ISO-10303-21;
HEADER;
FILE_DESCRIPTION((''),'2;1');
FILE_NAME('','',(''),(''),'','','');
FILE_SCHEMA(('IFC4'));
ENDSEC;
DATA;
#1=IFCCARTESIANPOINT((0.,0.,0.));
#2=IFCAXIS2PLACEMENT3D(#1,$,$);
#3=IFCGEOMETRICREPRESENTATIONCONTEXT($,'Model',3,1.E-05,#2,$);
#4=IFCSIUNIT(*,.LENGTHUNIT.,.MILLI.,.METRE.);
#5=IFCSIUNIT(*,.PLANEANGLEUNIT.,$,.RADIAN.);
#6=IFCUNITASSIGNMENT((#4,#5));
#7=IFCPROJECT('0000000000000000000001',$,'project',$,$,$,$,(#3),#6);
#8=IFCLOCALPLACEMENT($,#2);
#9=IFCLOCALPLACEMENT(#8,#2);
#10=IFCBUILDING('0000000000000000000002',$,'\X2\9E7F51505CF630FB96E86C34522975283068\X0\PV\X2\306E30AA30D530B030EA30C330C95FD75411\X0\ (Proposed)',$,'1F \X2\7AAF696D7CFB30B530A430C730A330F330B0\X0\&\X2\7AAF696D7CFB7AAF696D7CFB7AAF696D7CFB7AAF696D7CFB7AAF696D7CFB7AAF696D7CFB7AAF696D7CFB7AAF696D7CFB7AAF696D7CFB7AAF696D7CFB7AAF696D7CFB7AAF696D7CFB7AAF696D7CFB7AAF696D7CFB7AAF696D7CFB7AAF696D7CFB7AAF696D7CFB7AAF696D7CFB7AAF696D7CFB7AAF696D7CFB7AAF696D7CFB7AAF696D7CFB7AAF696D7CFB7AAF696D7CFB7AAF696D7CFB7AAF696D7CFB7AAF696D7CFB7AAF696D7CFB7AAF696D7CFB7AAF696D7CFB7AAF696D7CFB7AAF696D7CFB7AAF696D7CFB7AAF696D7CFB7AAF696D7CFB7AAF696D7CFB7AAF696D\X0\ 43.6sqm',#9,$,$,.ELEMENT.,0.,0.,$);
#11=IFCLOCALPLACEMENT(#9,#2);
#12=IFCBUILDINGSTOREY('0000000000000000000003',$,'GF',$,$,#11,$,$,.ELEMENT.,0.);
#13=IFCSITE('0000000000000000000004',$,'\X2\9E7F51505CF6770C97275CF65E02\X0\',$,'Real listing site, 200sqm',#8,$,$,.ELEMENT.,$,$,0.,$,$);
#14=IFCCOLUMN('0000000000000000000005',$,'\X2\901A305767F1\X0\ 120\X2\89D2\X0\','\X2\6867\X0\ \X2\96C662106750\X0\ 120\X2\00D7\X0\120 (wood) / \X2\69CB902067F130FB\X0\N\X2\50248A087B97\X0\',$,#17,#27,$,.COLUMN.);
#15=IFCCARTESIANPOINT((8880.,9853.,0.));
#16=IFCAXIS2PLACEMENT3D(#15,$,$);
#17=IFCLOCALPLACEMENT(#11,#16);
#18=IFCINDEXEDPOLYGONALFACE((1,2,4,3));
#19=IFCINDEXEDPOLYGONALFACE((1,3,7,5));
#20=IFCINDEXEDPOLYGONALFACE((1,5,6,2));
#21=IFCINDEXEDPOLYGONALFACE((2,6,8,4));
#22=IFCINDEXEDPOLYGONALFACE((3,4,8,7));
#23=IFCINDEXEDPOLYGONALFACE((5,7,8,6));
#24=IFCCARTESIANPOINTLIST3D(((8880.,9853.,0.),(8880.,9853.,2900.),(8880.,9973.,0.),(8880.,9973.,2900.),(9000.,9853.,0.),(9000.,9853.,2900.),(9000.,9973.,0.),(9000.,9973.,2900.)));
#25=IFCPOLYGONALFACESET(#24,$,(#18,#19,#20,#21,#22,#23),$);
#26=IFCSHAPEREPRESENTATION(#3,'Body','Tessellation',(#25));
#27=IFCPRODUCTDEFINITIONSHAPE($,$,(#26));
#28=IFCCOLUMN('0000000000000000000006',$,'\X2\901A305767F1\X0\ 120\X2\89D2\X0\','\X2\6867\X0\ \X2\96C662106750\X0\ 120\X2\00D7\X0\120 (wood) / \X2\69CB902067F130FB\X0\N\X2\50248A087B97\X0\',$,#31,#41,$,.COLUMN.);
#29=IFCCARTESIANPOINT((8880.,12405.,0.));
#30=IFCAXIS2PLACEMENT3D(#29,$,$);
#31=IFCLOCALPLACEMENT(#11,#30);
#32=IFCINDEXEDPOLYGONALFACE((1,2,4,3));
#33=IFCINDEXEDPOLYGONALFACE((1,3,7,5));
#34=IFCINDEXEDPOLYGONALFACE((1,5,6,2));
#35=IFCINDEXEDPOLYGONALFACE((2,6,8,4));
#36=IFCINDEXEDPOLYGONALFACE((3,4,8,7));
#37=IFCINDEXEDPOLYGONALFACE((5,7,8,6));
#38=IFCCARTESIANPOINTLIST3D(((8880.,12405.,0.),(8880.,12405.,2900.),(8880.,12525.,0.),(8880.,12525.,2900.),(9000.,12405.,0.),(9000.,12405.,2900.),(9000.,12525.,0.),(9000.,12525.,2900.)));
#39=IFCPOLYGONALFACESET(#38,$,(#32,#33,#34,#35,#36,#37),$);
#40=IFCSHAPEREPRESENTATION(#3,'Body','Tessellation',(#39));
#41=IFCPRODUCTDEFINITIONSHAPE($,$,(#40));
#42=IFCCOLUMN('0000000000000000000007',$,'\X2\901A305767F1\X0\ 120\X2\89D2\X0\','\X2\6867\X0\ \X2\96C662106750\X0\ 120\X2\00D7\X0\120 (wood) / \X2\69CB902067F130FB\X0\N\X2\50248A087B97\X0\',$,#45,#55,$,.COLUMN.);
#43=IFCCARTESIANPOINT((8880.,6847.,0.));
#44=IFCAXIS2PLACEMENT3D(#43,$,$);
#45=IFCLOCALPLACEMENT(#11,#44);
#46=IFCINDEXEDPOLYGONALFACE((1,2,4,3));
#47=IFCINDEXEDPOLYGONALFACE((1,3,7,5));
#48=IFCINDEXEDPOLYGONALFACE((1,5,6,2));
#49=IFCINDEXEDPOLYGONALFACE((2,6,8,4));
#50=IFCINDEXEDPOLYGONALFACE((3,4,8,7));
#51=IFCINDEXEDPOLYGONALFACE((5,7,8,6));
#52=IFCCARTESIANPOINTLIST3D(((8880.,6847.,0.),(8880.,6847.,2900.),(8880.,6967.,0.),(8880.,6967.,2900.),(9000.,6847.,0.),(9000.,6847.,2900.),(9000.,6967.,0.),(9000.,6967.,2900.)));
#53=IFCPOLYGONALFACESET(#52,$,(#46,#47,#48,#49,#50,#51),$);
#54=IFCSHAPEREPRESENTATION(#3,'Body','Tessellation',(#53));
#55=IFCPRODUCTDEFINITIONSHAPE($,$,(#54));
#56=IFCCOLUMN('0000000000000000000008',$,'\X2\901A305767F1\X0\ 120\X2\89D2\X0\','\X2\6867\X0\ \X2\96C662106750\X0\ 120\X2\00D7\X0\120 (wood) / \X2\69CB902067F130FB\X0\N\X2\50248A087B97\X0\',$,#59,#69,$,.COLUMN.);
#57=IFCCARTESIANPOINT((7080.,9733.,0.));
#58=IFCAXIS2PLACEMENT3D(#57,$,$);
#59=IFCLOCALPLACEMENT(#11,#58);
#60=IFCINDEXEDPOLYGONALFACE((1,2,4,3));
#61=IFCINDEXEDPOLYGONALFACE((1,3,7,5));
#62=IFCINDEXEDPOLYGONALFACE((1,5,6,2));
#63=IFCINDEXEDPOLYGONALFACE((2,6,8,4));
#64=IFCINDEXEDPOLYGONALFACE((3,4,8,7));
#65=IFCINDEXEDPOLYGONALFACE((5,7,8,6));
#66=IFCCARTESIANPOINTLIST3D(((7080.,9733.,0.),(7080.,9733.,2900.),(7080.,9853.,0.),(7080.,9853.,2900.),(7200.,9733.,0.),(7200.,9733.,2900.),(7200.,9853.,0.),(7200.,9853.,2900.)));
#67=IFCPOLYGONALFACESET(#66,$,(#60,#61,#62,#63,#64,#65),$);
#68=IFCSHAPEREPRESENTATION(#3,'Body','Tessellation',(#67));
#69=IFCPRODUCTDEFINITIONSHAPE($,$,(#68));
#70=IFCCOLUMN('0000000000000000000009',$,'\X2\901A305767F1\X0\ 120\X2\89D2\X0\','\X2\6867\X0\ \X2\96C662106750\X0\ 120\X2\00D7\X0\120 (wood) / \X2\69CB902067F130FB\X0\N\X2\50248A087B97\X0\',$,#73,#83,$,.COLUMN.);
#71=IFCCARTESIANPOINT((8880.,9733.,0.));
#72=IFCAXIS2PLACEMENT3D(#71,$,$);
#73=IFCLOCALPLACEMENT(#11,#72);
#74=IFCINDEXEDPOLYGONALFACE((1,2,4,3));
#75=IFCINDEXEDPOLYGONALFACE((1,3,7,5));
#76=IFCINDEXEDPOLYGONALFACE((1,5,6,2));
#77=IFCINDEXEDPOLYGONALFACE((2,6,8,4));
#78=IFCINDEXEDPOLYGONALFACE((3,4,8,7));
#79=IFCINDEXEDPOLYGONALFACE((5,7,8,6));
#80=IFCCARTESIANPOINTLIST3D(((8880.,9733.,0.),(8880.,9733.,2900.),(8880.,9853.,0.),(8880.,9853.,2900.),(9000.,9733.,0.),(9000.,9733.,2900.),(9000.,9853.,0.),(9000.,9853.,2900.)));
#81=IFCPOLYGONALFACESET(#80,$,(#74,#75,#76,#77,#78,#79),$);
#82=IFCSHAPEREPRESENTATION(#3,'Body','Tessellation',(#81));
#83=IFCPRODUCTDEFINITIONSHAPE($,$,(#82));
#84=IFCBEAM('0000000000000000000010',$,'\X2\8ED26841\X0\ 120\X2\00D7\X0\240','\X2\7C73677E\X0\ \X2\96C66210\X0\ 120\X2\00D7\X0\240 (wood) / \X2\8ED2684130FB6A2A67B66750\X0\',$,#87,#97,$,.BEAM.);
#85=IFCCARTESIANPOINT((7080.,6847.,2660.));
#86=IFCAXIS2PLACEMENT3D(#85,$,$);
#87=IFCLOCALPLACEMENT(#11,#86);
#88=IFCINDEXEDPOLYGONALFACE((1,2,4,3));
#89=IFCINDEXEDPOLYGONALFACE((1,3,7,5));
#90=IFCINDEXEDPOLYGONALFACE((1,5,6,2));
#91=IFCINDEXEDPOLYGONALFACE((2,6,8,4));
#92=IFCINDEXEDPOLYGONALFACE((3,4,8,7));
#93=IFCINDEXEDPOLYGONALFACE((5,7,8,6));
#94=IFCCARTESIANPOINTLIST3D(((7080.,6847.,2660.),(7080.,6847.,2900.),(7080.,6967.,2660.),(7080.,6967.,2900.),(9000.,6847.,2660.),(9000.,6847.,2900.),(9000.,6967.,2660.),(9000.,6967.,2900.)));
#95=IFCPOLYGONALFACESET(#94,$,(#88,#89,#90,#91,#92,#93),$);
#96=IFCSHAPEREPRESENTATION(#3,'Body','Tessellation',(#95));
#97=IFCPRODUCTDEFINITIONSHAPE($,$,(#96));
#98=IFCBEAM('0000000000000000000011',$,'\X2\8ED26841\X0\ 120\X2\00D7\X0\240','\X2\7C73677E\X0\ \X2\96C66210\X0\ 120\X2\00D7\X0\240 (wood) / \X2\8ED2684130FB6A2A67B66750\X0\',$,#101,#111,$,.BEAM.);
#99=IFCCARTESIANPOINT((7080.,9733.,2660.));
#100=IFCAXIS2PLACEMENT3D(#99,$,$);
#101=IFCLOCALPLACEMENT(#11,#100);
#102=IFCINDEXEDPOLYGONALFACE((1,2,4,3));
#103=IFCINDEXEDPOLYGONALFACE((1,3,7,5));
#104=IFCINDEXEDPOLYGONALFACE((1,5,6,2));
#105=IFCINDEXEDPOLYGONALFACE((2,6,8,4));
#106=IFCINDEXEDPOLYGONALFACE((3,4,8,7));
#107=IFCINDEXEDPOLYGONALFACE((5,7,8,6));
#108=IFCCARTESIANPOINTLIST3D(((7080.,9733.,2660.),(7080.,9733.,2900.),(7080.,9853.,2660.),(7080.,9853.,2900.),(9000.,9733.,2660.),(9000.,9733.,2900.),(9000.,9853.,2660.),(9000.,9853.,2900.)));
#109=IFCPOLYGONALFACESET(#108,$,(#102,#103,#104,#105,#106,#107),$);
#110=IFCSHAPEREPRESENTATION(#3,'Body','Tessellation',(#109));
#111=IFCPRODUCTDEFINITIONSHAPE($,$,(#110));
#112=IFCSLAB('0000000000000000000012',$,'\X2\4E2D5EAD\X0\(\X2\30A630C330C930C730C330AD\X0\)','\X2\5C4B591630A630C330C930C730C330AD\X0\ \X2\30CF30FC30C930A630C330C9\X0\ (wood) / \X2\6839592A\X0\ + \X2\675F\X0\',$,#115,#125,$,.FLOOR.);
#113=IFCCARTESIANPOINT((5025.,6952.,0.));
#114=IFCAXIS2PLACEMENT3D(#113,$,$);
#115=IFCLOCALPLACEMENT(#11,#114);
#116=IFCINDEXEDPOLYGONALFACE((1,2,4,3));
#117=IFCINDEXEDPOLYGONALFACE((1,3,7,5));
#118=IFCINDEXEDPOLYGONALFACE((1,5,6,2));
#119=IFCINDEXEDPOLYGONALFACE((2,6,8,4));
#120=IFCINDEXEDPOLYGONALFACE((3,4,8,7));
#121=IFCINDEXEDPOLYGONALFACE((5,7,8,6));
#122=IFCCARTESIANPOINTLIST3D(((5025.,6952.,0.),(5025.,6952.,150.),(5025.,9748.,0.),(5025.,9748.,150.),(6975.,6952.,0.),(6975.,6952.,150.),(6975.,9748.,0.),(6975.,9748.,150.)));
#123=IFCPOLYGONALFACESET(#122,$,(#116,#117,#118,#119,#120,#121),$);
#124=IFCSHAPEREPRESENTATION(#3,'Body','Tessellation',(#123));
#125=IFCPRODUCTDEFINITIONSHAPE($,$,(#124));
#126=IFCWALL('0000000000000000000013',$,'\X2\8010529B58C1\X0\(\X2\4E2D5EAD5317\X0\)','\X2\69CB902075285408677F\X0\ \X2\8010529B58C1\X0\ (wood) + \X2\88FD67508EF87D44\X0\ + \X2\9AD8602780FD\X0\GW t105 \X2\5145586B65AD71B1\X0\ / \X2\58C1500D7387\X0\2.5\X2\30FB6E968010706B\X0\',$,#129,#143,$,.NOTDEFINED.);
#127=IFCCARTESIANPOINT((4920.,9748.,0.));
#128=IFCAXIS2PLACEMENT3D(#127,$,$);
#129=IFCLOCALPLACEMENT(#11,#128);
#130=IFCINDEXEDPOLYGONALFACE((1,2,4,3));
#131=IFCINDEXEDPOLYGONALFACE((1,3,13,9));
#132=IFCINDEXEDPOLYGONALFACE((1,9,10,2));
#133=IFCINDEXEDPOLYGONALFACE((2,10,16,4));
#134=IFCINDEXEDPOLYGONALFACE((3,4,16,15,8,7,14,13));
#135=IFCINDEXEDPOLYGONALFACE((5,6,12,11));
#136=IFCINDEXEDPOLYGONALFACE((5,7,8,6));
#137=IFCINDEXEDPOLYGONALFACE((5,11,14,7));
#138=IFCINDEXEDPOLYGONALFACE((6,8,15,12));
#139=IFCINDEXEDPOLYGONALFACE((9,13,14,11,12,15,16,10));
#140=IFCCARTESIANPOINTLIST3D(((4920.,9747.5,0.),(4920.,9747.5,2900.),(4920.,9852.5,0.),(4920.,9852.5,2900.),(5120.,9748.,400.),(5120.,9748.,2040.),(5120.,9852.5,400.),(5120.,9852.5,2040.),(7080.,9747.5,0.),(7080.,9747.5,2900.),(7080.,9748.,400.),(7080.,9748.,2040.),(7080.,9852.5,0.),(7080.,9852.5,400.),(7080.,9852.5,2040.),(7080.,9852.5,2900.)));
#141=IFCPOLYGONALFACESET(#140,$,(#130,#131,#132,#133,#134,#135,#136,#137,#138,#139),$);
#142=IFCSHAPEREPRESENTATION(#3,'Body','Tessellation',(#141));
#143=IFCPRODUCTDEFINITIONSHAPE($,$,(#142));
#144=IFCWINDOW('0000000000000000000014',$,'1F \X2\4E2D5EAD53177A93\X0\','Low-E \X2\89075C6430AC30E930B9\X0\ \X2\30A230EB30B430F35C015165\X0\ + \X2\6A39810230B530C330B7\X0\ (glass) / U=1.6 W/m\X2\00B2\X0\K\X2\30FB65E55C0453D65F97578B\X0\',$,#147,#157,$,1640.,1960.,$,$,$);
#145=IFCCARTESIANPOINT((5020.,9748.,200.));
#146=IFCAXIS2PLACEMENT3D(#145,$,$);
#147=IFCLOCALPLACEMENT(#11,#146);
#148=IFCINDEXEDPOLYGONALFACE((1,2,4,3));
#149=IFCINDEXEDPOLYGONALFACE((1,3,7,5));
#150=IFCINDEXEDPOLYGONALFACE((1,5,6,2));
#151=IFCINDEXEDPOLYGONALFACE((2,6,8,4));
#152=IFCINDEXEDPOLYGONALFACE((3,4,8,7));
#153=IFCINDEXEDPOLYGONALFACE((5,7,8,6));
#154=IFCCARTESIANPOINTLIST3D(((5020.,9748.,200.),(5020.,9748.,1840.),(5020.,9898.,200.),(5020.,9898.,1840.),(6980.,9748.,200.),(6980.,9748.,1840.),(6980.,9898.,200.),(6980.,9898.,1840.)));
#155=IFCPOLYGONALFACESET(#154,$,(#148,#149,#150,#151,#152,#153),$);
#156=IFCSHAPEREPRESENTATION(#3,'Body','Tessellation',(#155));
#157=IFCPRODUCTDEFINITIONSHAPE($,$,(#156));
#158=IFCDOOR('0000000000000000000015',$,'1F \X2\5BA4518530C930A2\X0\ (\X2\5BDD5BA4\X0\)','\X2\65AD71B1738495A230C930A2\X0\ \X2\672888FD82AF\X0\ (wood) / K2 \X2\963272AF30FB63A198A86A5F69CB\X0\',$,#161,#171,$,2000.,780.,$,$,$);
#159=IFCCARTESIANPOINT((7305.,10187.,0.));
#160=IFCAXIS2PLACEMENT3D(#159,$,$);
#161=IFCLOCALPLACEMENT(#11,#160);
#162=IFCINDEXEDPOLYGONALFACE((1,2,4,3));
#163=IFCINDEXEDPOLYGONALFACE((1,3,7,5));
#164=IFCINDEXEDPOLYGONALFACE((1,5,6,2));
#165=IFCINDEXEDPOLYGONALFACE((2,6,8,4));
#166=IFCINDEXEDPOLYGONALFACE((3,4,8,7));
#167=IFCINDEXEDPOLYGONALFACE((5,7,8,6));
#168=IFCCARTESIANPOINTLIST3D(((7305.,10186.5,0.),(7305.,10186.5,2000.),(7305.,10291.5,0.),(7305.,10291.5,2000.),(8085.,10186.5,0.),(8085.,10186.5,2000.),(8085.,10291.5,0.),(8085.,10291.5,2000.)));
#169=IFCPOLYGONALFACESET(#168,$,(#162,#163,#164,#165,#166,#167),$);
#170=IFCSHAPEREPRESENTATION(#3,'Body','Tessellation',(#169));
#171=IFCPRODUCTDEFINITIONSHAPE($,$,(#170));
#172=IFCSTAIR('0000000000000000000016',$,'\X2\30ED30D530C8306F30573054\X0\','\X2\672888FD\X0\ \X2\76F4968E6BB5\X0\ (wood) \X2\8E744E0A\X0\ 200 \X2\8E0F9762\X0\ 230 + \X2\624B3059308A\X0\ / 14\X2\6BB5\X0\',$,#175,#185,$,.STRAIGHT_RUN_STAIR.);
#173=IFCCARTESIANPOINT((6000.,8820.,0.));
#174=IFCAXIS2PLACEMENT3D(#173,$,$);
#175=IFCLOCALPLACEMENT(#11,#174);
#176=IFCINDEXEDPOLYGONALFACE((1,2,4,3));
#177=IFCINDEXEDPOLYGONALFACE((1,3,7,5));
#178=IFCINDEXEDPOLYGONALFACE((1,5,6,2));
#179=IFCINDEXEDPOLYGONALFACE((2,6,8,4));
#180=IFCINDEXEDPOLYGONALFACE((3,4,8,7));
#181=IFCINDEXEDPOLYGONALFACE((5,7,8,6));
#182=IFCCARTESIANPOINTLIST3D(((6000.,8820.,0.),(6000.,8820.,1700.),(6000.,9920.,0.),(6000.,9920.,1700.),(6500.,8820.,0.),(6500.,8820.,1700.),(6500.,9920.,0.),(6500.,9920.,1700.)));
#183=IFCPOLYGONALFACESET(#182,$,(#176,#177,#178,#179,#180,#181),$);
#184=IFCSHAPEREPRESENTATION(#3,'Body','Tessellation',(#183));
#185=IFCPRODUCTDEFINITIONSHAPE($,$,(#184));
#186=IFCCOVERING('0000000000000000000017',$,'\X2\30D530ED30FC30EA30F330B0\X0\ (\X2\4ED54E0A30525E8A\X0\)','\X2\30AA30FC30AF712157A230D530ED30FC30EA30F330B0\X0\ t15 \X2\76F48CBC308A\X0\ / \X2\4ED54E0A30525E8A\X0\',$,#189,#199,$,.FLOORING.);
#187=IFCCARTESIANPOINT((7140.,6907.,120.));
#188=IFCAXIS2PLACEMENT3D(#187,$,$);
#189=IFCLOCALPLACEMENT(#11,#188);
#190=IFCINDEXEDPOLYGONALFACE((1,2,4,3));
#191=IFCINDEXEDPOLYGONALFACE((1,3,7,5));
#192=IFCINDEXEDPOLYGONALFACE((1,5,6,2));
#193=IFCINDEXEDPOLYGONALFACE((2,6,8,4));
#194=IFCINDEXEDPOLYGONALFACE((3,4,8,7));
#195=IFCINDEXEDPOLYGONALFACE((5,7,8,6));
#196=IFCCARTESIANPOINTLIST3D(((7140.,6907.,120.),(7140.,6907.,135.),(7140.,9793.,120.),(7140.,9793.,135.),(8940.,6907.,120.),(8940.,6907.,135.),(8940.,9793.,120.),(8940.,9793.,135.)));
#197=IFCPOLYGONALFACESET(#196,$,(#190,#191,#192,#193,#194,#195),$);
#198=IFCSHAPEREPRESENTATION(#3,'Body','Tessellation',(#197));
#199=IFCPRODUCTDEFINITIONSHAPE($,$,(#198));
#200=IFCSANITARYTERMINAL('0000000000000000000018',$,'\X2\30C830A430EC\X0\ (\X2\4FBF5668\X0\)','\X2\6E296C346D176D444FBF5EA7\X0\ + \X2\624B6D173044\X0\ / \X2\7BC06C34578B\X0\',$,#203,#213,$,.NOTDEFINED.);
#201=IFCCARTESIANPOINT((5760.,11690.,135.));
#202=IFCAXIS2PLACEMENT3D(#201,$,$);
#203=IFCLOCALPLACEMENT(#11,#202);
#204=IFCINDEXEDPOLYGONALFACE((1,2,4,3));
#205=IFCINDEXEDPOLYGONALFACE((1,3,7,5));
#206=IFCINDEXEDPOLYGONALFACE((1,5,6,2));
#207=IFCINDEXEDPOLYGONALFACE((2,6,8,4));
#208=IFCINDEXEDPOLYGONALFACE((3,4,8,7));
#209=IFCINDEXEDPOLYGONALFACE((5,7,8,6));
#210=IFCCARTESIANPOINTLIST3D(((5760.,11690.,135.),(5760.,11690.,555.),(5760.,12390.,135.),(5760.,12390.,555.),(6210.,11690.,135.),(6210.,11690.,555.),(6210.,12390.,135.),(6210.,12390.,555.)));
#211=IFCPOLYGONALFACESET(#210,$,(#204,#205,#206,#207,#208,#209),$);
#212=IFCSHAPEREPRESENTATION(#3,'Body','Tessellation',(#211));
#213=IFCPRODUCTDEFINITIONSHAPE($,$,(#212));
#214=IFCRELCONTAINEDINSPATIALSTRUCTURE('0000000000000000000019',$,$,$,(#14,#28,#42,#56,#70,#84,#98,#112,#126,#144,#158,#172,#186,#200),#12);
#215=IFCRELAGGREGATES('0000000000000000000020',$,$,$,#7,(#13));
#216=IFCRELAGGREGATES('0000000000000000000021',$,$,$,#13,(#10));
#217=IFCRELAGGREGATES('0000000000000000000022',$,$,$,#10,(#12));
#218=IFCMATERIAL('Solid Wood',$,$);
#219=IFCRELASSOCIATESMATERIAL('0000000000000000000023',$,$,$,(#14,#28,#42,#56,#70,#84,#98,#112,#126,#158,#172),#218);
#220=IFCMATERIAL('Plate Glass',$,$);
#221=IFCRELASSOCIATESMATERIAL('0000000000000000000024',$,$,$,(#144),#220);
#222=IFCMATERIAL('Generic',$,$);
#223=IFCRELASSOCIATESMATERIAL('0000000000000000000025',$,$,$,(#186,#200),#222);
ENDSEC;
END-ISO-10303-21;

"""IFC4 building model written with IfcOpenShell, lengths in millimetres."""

from ifc_helpers import new_model, si_unit, frame, frame_2d, origin, place, context, project, spatial, rectangle, extrude, material, element, fill, save


model = new_model("IFC4")

# Units and contexts
model_context = context("Model", 3, precision=1e-05, world=origin())
ifc_project = project(units=[si_unit("LENGTHUNIT", "METRE", prefix="MILLI"), si_unit("PLANEANGLEUNIT", "RADIAN")], contexts=[model_context])

# Site, building, storey
site_placement = place(None, origin())
site = spatial("IfcSite", under=ifc_project, at=site_placement, Name="鹿児島県霧島市", ObjectType="Real listing site, 200sqm", CompositionType="ELEMENT", RefElevation=0.0)
building_placement = place(site_placement, origin())
building = spatial("IfcBuilding", under=site, at=building_placement, Name="鹿児島・雨水利用とPVのオフグリッド志向 (Proposed)", ObjectType="1F 窯業系サイディング&窯業系窯業系窯業系窯業系窯業系窯業系窯業系窯業系窯業系窯業系窯業系窯業系窯業系窯業系窯業系窯業系窯業系窯業系窯業系窯業系窯業系窯業系窯業系窯業系窯業系窯業系窯業系窯業系窯業系窯業系窯業系窯業系窯業系窯業系窯業系窯業系窯業 43.6sqm", CompositionType="ELEMENT", ElevationOfRefHeight=0.0, ElevationOfTerrain=0.0)
storey_placement = place(building_placement, origin())
storey = spatial("IfcBuildingStorey", under=building, at=storey_placement, Name="GF", CompositionType="ELEMENT", Elevation=0.0)

# Columns
ifc_material_1 = material(Name="Solid Wood")
column_1_placement = place(storey_placement, frame((8880.0, 9853.0, 0.0)))
element("IfcColumn", 1, at=column_1_placement, inside=storey, material=ifc_material_1, Name="通し柱 120角", Description="桧 集成材 120×120 (wood) / 構造柱・N値計算", PredefinedType="COLUMN", context=model_context, shape_type="SweptSolid", body=[
    extrude(rectangle(XDim=120.0, YDim=120.0, at=frame_2d((60.0, 60.0))), frame((8880.0, 9853.0, 0.0)), (0.0, 0.0, 1.0), 2900.0),
])
column_2_placement = place(storey_placement, frame((8880.0, 12405.0, 0.0)))
element("IfcColumn", 2, at=column_2_placement, inside=storey, material=ifc_material_1, Name="通し柱 120角", Description="桧 集成材 120×120 (wood) / 構造柱・N値計算", PredefinedType="COLUMN", context=model_context, shape_type="SweptSolid", body=[
    extrude(rectangle(XDim=120.0, YDim=120.0, at=frame_2d((60.0, 60.0))), frame((8880.0, 12405.0, 0.0)), (0.0, 0.0, 1.0), 2900.0),
])
column_3_placement = place(storey_placement, frame((8880.0, 6847.0, 0.0)))
element("IfcColumn", 3, at=column_3_placement, inside=storey, material=ifc_material_1, Name="通し柱 120角", Description="桧 集成材 120×120 (wood) / 構造柱・N値計算", PredefinedType="COLUMN", context=model_context, shape_type="SweptSolid", body=[
    extrude(rectangle(XDim=120.0, YDim=120.0, at=frame_2d((60.0, 60.0))), frame((8880.0, 6847.0, 0.0)), (0.0, 0.0, 1.0), 2900.0),
])
column_4_placement = place(storey_placement, frame((7080.0, 9733.0, 0.0)))
element("IfcColumn", 4, at=column_4_placement, inside=storey, material=ifc_material_1, Name="通し柱 120角", Description="桧 集成材 120×120 (wood) / 構造柱・N値計算", PredefinedType="COLUMN", context=model_context, shape_type="SweptSolid", body=[
    extrude(rectangle(XDim=120.0, YDim=120.0, at=frame_2d((60.0, 60.0))), frame((7080.0, 9733.0, 0.0)), (0.0, 0.0, 1.0), 2900.0),
])
column_5_placement = place(storey_placement, frame((8880.0, 9733.0, 0.0)))
element("IfcColumn", 5, at=column_5_placement, inside=storey, material=ifc_material_1, Name="通し柱 120角", Description="桧 集成材 120×120 (wood) / 構造柱・N値計算", PredefinedType="COLUMN", context=model_context, shape_type="SweptSolid", body=[
    extrude(rectangle(XDim=120.0, YDim=120.0, at=frame_2d((60.0, 60.0))), frame((8880.0, 9733.0, 0.0)), (0.0, 0.0, 1.0), 2900.0),
])

# Beams
beam_1_placement = place(storey_placement, frame((7080.0, 6847.0, 2660.0)))
element("IfcBeam", 6, at=beam_1_placement, inside=storey, material=ifc_material_1, Name="軒桁 120×240", Description="米松 集成 120×240 (wood) / 軒桁・横架材", PredefinedType="BEAM", context=model_context, shape_type="SweptSolid", body=[
    extrude(rectangle(XDim=1920.0, YDim=120.0, at=frame_2d((960.0, 60.0))), frame((7080.0, 6847.0, 2660.0)), (0.0, 0.0, 1.0), 240.0),
])
beam_2_placement = place(storey_placement, frame((7080.0, 9733.0, 2660.0)))
element("IfcBeam", 7, at=beam_2_placement, inside=storey, material=ifc_material_1, Name="軒桁 120×240", Description="米松 集成 120×240 (wood) / 軒桁・横架材", PredefinedType="BEAM", context=model_context, shape_type="SweptSolid", body=[
    extrude(rectangle(XDim=1920.0, YDim=120.0, at=frame_2d((960.0, 60.0))), frame((7080.0, 9733.0, 2660.0)), (0.0, 0.0, 1.0), 240.0),
])

# Slab
slab_placement = place(storey_placement, frame((5025.0, 6952.0, 0.0)))
element("IfcSlab", 8, at=slab_placement, inside=storey, material=ifc_material_1, Name="中庭(ウッドデッキ)", Description="屋外ウッドデッキ ハードウッド (wood) / 根太 + 束", PredefinedType="FLOOR", context=model_context, shape_type="SweptSolid", body=[
    extrude(rectangle(XDim=1950.0, YDim=2796.0, at=frame_2d((975.0, 1398.0))), frame((5025.0, 6952.0, 0.0)), (0.0, 0.0, 1.0), 150.0),
])

# Wall, opening, window
wall_1_placement = place(storey_placement, frame((4920.0, 9748.0, 0.0)))
wall_1 = element("IfcWall", 9, at=wall_1_placement, inside=storey, material=ifc_material_1, Name="耐力壁(中庭北)", Description="構造用合板 耐力壁 (wood) + 製材軸組 + 高性能GW t105 充填断熱 / 壁倍率2.5・準耐火", PredefinedType="NOTDEFINED", context=model_context, shape_type="SweptSolid", body=[
    extrude(rectangle(XDim=2160.0, YDim=105.0, at=frame_2d((1080.0, 52.0))), frame((4920.0, 9748.0, 0.0)), (0.0, 0.0, 1.0), 2900.0),
])
opening_placement = place(storey_placement, frame((5020.0, 9748.0, 200.0)))
opening = element("IfcOpeningElement", 10, at=opening_placement, cuts=wall_1, PredefinedType="NOTDEFINED", context=model_context, shape_type="SweptSolid", body=[
    extrude(rectangle(XDim=1960.0, YDim=150.0, at=frame_2d((980.0, 75.0))), frame((5020.0, 9748.0, 200.0)), (0.0, 0.0, 1.0), 1640.0),
])
ifc_material_2 = material(Name="Plate Glass")
window_placement = place(storey_placement, frame((5020.0, 9748.0, 200.0)))
window = element("IfcWindow", 11, at=window_placement, inside=storey, material=ifc_material_2, Name="1F 中庭北窓", Description="Low-E 複層ガラス アルゴン封入 + 樹脂サッシ (glass) / U=1.6 W/m²K・日射取得型", OverallHeight=1640.0, OverallWidth=1960.0, context=model_context, shape_type="SweptSolid", body=[
    extrude(rectangle(XDim=1960.0, YDim=150.0, at=frame_2d((980.0, 75.0))), frame((5020.0, 9748.0, 200.0)), (0.0, 0.0, 1.0), 1640.0),
])
fill(opening, window)

# Door
door_placement = place(storey_placement, frame((7305.0, 10187.0, 0.0)))
element("IfcDoor", 12, at=door_placement, inside=storey, material=ifc_material_1, Name="1F 室内ドア (寝室)", Description="断熱玄関ドア 木製芯 (wood) / K2 防犯・採風機構", OverallHeight=2000.0, OverallWidth=780.0, context=model_context, shape_type="SweptSolid", body=[
    extrude(rectangle(XDim=780.0, YDim=105.0, at=frame_2d((390.0, 52.0))), frame((7305.0, 10187.0, 0.0)), (0.0, 0.0, 1.0), 2000.0),
])

# Stair
stair_placement = place(storey_placement, frame((6000.0, 8820.0, 0.0)))
element("IfcStair", 13, at=stair_placement, inside=storey, material=ifc_material_1, Name="ロフトはしご", Description="木製 直階段 (wood) 蹴上 200 踏面 230 + 手すり / 14段", PredefinedType="STRAIGHT_RUN_STAIR", context=model_context, shape_type="SweptSolid", body=[
    extrude(rectangle(XDim=500.0, YDim=1100.0, at=frame_2d((250.0, 550.0))), frame((6000.0, 8820.0, 0.0)), (0.0, 0.0, 1.0), 1700.0),
])

# Covering
ifc_material_3 = material(Name="Generic")
covering_placement = place(storey_placement, frame((7140.0, 6907.0, 120.0)))
element("IfcCovering", 14, at=covering_placement, inside=storey, material=ifc_material_3, Name="フローリング (仕上げ床)", Description="オーク無垢フローリング t15 直貼り / 仕上げ床", PredefinedType="FLOORING", context=model_context, shape_type="SweptSolid", body=[
    extrude(rectangle(XDim=1800.0, YDim=2886.0, at=frame_2d((900.0, 1443.0))), frame((7140.0, 6907.0, 120.0)), (0.0, 0.0, 1.0), 15.0),
])

# Sanitary terminal
sanitary_terminal_placement = place(storey_placement, frame((5760.0, 11690.0, 135.0)))
element("IfcSanitaryTerminal", 15, at=sanitary_terminal_placement, inside=storey, material=ifc_material_3, Name="トイレ (便器)", Description="温水洗浄便座 + 手洗い / 節水型", PredefinedType="NOTDEFINED", context=model_context, shape_type="SweptSolid", body=[
    extrude(rectangle(XDim=450.0, YDim=700.0, at=frame_2d((225.0, 350.0))), frame((5760.0, 11690.0, 135.0)), (0.0, 0.0, 1.0), 420.0),
])

save(model, "model.ifc")
